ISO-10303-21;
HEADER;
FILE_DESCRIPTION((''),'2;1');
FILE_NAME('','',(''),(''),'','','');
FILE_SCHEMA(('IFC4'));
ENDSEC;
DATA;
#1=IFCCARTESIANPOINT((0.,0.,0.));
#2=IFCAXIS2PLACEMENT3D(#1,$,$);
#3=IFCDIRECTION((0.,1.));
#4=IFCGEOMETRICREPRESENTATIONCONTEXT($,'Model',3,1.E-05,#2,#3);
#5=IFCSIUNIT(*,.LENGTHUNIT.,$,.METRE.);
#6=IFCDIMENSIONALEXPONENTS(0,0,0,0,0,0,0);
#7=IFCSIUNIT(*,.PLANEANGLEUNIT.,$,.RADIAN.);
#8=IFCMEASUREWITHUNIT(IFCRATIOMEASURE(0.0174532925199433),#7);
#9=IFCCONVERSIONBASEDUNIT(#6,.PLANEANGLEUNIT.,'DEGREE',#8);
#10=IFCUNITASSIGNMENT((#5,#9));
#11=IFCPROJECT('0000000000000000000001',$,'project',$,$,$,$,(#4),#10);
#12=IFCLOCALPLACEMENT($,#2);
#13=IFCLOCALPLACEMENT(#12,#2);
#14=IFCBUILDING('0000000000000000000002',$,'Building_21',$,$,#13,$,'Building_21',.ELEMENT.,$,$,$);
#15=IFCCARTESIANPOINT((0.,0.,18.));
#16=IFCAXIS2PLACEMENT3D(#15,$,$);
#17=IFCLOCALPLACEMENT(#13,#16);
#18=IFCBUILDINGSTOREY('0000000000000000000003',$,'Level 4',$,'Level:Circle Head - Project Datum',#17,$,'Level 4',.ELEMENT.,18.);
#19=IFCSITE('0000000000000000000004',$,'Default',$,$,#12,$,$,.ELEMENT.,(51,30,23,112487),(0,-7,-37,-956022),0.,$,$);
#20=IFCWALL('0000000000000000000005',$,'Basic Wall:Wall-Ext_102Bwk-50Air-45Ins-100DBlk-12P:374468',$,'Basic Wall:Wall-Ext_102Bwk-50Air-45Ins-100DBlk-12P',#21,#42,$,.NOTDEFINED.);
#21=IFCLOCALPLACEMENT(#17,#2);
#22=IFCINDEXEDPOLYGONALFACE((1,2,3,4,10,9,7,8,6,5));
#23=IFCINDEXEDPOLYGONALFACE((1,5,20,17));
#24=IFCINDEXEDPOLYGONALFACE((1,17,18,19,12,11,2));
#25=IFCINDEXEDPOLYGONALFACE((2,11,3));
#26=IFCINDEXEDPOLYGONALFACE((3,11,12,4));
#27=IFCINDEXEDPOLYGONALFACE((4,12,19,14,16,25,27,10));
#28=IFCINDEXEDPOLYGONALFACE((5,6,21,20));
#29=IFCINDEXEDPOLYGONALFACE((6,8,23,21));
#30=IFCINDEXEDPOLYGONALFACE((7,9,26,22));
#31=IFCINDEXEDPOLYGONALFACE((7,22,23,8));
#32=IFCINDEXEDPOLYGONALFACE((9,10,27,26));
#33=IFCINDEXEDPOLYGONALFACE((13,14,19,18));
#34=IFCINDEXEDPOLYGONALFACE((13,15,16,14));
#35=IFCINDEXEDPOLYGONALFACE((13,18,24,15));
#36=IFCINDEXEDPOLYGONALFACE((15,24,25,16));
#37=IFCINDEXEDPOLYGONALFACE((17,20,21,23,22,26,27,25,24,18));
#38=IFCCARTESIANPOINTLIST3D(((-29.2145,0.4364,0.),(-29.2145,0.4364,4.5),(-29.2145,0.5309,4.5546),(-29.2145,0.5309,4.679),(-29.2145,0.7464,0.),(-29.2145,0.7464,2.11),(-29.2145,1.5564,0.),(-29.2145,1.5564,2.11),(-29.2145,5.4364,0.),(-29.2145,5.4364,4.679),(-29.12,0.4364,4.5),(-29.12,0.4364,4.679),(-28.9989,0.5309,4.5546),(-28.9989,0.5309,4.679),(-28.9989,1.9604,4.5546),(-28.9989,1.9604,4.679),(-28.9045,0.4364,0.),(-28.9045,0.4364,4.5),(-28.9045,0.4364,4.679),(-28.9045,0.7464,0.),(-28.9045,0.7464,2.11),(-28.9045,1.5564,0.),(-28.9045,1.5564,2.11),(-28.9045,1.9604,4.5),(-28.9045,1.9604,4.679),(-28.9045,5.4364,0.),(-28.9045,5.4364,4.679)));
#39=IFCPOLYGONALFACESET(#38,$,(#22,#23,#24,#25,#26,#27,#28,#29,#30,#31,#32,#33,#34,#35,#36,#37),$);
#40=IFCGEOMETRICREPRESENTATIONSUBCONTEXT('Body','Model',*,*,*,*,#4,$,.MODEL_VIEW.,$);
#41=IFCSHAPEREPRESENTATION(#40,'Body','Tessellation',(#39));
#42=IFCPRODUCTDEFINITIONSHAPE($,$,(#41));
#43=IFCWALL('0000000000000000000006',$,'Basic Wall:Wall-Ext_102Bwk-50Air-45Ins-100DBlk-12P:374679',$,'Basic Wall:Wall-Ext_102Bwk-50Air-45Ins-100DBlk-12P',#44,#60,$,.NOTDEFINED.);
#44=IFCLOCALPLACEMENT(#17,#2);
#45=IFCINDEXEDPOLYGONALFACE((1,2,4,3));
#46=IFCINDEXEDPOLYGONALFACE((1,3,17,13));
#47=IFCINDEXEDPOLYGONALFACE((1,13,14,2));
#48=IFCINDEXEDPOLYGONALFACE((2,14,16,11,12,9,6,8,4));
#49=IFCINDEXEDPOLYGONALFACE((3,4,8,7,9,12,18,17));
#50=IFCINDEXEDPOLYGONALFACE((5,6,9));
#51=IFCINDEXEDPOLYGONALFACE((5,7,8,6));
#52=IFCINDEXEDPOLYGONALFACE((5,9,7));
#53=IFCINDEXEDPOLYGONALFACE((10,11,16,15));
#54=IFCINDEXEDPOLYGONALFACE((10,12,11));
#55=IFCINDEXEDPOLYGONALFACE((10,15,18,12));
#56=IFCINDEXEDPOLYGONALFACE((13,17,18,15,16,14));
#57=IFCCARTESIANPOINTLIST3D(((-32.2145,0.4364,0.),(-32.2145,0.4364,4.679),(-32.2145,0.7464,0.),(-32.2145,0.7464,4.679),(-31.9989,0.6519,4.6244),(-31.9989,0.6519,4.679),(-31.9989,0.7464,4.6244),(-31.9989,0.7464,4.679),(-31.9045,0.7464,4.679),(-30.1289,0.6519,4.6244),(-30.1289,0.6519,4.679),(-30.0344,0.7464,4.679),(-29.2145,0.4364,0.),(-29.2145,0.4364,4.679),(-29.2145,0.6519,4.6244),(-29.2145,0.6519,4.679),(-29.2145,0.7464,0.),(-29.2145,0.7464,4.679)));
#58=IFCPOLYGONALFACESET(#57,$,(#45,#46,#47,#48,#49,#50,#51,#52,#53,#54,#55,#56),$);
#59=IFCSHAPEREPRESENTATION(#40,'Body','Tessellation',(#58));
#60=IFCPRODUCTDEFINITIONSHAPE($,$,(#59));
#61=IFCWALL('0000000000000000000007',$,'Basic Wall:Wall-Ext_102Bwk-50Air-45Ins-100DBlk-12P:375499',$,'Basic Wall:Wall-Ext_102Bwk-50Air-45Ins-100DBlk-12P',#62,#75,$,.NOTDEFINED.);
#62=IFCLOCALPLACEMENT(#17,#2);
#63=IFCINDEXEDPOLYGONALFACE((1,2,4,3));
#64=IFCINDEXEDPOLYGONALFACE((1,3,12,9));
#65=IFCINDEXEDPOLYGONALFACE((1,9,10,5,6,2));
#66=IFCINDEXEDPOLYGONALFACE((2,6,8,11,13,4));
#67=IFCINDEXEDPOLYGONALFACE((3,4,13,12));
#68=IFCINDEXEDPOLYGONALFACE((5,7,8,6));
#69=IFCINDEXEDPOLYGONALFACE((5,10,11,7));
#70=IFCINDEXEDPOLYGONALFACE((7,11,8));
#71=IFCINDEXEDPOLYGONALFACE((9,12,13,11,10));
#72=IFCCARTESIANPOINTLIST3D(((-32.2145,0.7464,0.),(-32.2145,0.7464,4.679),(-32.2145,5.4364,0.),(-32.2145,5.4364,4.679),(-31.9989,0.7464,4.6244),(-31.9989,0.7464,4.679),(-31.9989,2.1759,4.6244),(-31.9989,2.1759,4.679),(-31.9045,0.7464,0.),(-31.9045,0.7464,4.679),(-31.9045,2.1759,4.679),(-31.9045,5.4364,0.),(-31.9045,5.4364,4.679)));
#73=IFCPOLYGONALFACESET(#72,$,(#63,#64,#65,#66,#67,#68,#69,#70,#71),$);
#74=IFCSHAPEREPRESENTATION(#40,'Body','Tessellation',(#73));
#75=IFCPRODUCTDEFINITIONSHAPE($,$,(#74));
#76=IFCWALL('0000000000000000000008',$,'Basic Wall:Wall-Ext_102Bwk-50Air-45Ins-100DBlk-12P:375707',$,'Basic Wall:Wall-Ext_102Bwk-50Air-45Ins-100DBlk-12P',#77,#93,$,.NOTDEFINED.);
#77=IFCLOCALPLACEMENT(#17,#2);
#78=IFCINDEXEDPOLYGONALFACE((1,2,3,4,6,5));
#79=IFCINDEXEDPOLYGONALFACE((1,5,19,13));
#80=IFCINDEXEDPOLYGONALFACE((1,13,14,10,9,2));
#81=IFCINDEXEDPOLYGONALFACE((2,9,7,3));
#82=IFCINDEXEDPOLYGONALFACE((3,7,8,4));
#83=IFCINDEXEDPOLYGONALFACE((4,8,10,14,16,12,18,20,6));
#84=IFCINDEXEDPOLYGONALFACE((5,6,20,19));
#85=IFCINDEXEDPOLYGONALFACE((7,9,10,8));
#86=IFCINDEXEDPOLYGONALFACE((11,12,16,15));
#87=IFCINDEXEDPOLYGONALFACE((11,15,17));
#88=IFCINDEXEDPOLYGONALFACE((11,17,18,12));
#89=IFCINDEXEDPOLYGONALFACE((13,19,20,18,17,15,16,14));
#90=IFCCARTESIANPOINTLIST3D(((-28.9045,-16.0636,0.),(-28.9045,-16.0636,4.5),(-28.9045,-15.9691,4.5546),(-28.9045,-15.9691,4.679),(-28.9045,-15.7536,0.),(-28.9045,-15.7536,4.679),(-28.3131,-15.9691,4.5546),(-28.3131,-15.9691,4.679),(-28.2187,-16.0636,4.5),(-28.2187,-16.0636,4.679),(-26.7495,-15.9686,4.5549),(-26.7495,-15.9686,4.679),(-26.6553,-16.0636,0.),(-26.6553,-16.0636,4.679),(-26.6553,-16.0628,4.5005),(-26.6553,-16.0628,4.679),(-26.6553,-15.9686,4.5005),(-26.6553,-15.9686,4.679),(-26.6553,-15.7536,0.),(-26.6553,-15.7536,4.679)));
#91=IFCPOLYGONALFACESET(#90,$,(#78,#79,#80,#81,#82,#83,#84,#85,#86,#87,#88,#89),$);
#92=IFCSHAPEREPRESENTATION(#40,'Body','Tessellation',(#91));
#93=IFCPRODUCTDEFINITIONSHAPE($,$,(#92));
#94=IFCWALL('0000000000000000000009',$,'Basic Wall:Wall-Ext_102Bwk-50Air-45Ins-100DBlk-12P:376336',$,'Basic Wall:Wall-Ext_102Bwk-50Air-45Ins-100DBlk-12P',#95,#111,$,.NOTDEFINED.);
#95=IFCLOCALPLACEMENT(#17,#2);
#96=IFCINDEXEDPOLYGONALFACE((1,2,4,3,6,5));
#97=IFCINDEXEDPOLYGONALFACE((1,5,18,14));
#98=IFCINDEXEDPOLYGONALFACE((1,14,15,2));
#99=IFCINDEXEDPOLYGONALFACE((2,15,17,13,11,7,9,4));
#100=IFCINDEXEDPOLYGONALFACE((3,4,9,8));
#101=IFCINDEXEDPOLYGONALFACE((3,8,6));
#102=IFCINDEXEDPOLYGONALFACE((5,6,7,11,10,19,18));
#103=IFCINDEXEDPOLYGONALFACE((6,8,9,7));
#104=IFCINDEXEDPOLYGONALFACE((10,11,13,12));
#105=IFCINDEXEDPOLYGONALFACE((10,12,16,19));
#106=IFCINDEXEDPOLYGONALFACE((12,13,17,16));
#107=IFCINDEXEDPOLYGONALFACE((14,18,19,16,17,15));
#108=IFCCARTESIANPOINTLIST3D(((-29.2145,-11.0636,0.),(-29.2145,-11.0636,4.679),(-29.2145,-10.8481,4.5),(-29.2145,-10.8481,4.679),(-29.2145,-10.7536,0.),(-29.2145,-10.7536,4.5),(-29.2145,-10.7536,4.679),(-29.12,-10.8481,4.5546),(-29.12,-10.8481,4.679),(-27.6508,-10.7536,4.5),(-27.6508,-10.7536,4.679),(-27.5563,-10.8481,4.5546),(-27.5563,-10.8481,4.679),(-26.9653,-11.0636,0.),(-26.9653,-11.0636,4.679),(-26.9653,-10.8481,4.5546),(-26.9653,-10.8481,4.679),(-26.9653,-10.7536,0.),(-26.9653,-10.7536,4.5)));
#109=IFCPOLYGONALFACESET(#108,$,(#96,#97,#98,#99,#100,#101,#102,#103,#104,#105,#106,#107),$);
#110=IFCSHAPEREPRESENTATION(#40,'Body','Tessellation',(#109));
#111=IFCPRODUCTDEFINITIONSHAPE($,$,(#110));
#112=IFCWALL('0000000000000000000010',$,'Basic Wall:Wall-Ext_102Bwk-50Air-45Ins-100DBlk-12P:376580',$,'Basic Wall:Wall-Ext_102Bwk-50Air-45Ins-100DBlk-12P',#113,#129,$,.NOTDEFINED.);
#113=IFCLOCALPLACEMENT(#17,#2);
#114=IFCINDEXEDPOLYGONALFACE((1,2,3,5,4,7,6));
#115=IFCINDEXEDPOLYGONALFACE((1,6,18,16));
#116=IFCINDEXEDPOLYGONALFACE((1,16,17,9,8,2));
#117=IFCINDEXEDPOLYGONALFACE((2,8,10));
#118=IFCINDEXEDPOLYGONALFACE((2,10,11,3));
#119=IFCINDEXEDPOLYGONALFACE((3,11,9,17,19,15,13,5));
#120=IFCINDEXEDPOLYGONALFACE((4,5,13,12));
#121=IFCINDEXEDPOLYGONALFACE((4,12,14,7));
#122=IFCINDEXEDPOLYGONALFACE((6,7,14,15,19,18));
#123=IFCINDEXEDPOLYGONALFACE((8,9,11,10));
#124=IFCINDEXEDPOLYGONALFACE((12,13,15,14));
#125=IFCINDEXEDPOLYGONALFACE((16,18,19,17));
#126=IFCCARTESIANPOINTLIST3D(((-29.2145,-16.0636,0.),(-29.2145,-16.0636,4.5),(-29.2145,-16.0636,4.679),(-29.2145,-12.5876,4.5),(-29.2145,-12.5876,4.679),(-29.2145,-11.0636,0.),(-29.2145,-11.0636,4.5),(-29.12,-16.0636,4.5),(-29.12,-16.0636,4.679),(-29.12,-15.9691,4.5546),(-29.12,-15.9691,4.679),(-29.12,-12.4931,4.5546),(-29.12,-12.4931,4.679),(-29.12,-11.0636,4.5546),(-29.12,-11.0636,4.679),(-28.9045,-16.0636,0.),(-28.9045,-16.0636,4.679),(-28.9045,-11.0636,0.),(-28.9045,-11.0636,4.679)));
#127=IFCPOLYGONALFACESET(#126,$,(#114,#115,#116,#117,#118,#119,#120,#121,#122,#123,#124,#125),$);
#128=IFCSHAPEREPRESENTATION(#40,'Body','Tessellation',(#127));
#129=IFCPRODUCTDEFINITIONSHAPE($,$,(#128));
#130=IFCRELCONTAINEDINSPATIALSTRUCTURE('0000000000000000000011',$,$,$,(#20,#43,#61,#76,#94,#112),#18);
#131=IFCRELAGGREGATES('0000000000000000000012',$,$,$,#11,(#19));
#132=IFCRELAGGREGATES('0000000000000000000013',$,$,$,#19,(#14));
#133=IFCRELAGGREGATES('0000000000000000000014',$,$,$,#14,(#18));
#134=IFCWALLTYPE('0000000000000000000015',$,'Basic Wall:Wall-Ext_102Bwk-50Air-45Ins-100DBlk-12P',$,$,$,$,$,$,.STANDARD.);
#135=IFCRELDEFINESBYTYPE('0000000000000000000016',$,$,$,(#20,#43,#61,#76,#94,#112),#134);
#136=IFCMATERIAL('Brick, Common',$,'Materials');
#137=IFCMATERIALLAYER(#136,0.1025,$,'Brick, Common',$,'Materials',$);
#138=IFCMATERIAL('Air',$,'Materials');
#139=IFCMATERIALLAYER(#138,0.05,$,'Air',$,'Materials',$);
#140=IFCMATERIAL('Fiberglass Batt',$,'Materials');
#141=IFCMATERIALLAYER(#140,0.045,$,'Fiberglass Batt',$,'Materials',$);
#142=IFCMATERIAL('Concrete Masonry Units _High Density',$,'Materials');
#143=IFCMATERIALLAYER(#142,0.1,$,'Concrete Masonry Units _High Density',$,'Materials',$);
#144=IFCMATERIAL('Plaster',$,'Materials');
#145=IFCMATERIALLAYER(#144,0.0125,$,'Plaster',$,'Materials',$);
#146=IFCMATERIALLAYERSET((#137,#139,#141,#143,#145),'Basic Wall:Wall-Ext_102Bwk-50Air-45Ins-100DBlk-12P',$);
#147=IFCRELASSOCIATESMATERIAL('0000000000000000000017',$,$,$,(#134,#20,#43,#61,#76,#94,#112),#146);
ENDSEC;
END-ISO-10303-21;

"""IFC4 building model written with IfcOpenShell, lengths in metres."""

from ifc_helpers import new_model, entity, si_unit, converted_unit, direction, frame, frame_2d, origin, place, context, subcontext, project, spatial, polyline, rectangle, extrude, clip, bounded_halfspace, material, layer, layer_set, layer_usage, type_object, element, save


model = new_model("IFC4")

# Units and contexts
model_context = context("Model", 3, precision=1e-05, world=origin(), true_north=direction((0.0, 1.0)))
body_context = subcontext(model_context, "Body", "Model", "MODEL_VIEW")
ifc_project = project(units=[si_unit("LENGTHUNIT", "METRE"), converted_unit("PLANEANGLEUNIT", "DEGREE", entity("IfcRatioMeasure", 0.0174532925199433), si_unit("PLANEANGLEUNIT", "RADIAN"), dimensions=[0, 0, 0, 0, 0, 0, 0])], contexts=[model_context])

# Site, building, storey
site_placement = place(None, origin())
site = spatial("IfcSite", under=ifc_project, at=site_placement, Name="Default", CompositionType="ELEMENT", RefLatitude=(51, 30, 23, 112487), RefLongitude=(0, -7, -37, -956022), RefElevation=0.0)
building_placement = place(site_placement, origin())
building = spatial("IfcBuilding", under=site, at=building_placement, Name="Building_21", LongName="Building_21", CompositionType="ELEMENT")
storey_placement = place(building_placement, frame((0.0, 0.0, 18.0)))
storey = spatial("IfcBuildingStorey", under=building, at=storey_placement, Name="Level 4", ObjectType="Level:Circle Head - Project Datum", LongName="Level 4", CompositionType="ELEMENT", Elevation=18.0)

# Shared definitions
ifc_material_1 = material(Name="Air", Category="Materials")

# Shared definitions
ifc_material_2 = material(Name="Brick, Common", Category="Materials")
ifc_layer_1 = layer(ifc_material_2, 0.1025, Name="Brick, Common", Category="Materials")
ifc_layer_2 = layer(ifc_material_1, 0.05, Name="Air", Category="Materials")
ifc_material_3 = material(Name="Fiberglass Batt", Category="Materials")
ifc_layer_3 = layer(ifc_material_3, 0.045, Name="Fiberglass Batt", Category="Materials")
ifc_material_4 = material(Name="Concrete Masonry Units _High Density", Category="Materials")
ifc_layer_4 = layer(ifc_material_4, 0.1, Name="Concrete Masonry Units _High Density", Category="Materials")
ifc_material_5 = material(Name="Plaster", Category="Materials")
ifc_layer_5 = layer(ifc_material_5, 0.0125, Name="Plaster", Category="Materials")
ifc_layer_set_1 = layer_set([ifc_layer_1, ifc_layer_2, ifc_layer_3, ifc_layer_4, ifc_layer_5], Name="Basic Wall:Wall-Ext_102Bwk-50Air-45Ins-100DBlk-12P")
wall_type = type_object("IfcWallType", Name="Basic Wall:Wall-Ext_102Bwk-50Air-45Ins-100DBlk-12P", PredefinedType="STANDARD", material=ifc_layer_set_1)

# Wall, opening
ifc_layer_usage_1 = layer_usage(ifc_layer_set_1, "AXIS2", "NEGATIVE", 0.155)
wall_1_placement = place(storey_placement, frame((-29.0595, 5.4364, 0.0), z_axis=(0.0, 0.0, 1.0), x_axis=(0.0, -1.0, 0.0)))
wall_1 = element("IfcWall", 1, at=wall_1_placement, inside=storey, type_object=wall_type, material=ifc_layer_usage_1, Name="Basic Wall:Wall-Ext_102Bwk-50Air-45Ins-100DBlk-12P:374468", ObjectType="Basic Wall:Wall-Ext_102Bwk-50Air-45Ins-100DBlk-12P", PredefinedType="NOTDEFINED", context=body_context, shape_type="Clipping", body=[
    clip(clip(extrude(rectangle(XDim=0.31, YDim=5.0, at=frame_2d((2.5, 0.0), x_axis=(0.0, 1.0))), origin(), (0.0, 0.0, 1.0), 4.679), bounded_halfspace(frame((5.0, 0.155, 4.5), z_axis=(0.0, 0.5, 0.866025), x_axis=(-1.0, 0.0, 0.0)), False, frame((5.0, 0.155, 4.5)), polyline([(0.0, 0.0), (-1.524, 0.0), (-1.524, -0.0945), (-0.0945, -0.0945), (0.0, 0.0)]))), bounded_halfspace(frame((5.0, -0.155, 4.5), z_axis=(0.5, 0.0, 0.866025), x_axis=(0.0, 1.0, 0.0)), False, frame((5.0, -0.155, 4.5)), polyline([(0.0, 0.0), (0.0, 0.0945), (-0.0945, 0.0), (0.0, 0.0)]))),
])
opening_1_placement = place(wall_1_placement, frame((3.88, -0.155, 0.0)))
element("IfcOpeningElement", 2, at=opening_1_placement, cuts=wall_1, PredefinedType="OPENING", context=body_context, shape_type="SweptSolid", body=[
    extrude(rectangle(XDim=2.11, YDim=0.81, at=frame_2d((1.055, 0.405), x_axis=(1.0, 0.0))), frame((0.0, 0.0, 0.0), z_axis=(0.0, 1.0, 0.0), x_axis=(0.0, 0.0, 1.0)), (0.0, 0.0, 1.0), 0.31),
])

# Walls
ifc_layer_usage_2 = layer_usage(ifc_layer_set_1, "AXIS2", "NEGATIVE", 0.155)
wall_2_placement = place(storey_placement, frame((-29.2145, 0.5914, 0.0), z_axis=(0.0, 0.0, 1.0), x_axis=(-1.0, 0.0, 0.0)))
element("IfcWall", 3, at=wall_2_placement, inside=storey, type_object=wall_type, material=ifc_layer_usage_2, Name="Basic Wall:Wall-Ext_102Bwk-50Air-45Ins-100DBlk-12P:374679", ObjectType="Basic Wall:Wall-Ext_102Bwk-50Air-45Ins-100DBlk-12P", PredefinedType="NOTDEFINED", context=body_context, shape_type="Clipping", body=[
    clip(clip(extrude(rectangle(XDim=3.0, YDim=0.31, at=frame_2d((1.5, 0.0), x_axis=(-1.0, 0.0))), origin(), (0.0, 0.0, 1.0), 4.679), bounded_halfspace(frame((0.0, -0.155, 4.679), z_axis=(0.0, 0.5, 0.866025), x_axis=(-1.0, 0.0, 0.0)), False, frame((0.0, -0.155, 4.679)), polyline([(0.0, 0.0), (0.8199, 0.0), (0.9144, 0.0945), (0.0, 0.0945), (0.0, 0.0)]))), bounded_halfspace(frame((2.69, -0.155, 4.679), z_axis=(0.5, 0.0, 0.866025), x_axis=(0.0, 1.0, 0.0)), False, frame((2.69, -0.155, 4.679)), polyline([(0.0, 0.0), (0.0945, 0.0), (0.0945, 0.0945), (0.0, 0.0)]))),
])
ifc_layer_usage_3 = layer_usage(ifc_layer_set_1, "AXIS2", "NEGATIVE", 0.155)
wall_3_placement = place(storey_placement, frame((-32.0595, 0.7464, 0.0), z_axis=(0.0, 0.0, 1.0), x_axis=(0.0, 1.0, 0.0)))
element("IfcWall", 4, at=wall_3_placement, inside=storey, type_object=wall_type, material=ifc_layer_usage_3, Name="Basic Wall:Wall-Ext_102Bwk-50Air-45Ins-100DBlk-12P:375499", ObjectType="Basic Wall:Wall-Ext_102Bwk-50Air-45Ins-100DBlk-12P", PredefinedType="NOTDEFINED", context=body_context, shape_type="Clipping", body=[
    clip(extrude(rectangle(XDim=4.69, YDim=0.31, at=frame_2d((2.345, 0.0), x_axis=(-1.0, 0.0))), origin(), (0.0, 0.0, 1.0), 4.679), bounded_halfspace(frame((0.0, -0.155, 4.679), z_axis=(0.0, 0.5, 0.866025), x_axis=(-1.0, 0.0, 0.0)), False, frame((0.0, -0.155, 4.679)), polyline([(0.0, 0.0), (1.4295, 0.0), (1.4295, 0.0945), (0.0, 0.0945), (0.0, 0.0)]))),
])

# Wall, opening
ifc_layer_usage_4 = layer_usage(ifc_layer_set_1, "AXIS2", "NEGATIVE", 0.155)
wall_4_placement = place(storey_placement, frame((-28.9045, -15.9086, 0.0)))
wall_4 = element("IfcWall", 5, at=wall_4_placement, inside=storey, type_object=wall_type, material=ifc_layer_usage_4, Name="Basic Wall:Wall-Ext_102Bwk-50Air-45Ins-100DBlk-12P:375707", ObjectType="Basic Wall:Wall-Ext_102Bwk-50Air-45Ins-100DBlk-12P", PredefinedType="NOTDEFINED", context=body_context, shape_type="Clipping", body=[
    clip(clip(extrude(rectangle(XDim=2.2492, YDim=0.31, at=frame_2d((1.1246, 0.0), x_axis=(-1.0, 0.0))), origin(), (0.0, 0.0, 1.0), 4.679), bounded_halfspace(frame((2.2492, -0.1542, 4.5005), z_axis=(0.5, 0.0, 0.866025), x_axis=(0.0, 1.0, 0.0)), False, frame((2.2492, -0.1542, 4.5005)), polyline([(0.0, 0.0), (0.0, 0.0942), (-0.0942, 0.0942), (0.0, 0.0)]))), bounded_halfspace(frame((0.0, -0.155, 4.5), z_axis=(0.0, -0.5, 0.866025), x_axis=(1.0, 0.0, 0.0)), False, frame((0.0, -0.155, 4.5)), polyline([(0.0, 0.0), (0.6858, 0.0), (0.5913, 0.0945), (0.0, 0.0945), (0.0, 0.0)]))),
])
opening_2_placement = place(wall_4_placement, frame((1.9392, 0.155, 0.0)))
element("IfcOpeningElement", 6, at=opening_2_placement, cuts=wall_4, PredefinedType="OPENING", context=body_context, shape_type="SweptSolid", body=[
    extrude(rectangle(XDim=2.11, YDim=0.31, at=frame_2d((0.0, 0.0), x_axis=(0.0, 1.0))), frame((0.155, 0.0, 1.055), z_axis=(0.0, 1.0, 0.0), x_axis=(-1.0, 0.0, 0.0)), (0.0, 0.0, 1.0), 0.81),
])

# Walls
ifc_layer_usage_5 = layer_usage(ifc_layer_set_1, "AXIS2", "NEGATIVE", 0.155)
wall_5_placement = place(storey_placement, frame((-26.9653, -10.9086, 0.0), z_axis=(0.0, 0.0, 1.0), x_axis=(-1.0, 0.0, 0.0)))
element("IfcWall", 7, at=wall_5_placement, inside=storey, type_object=wall_type, material=ifc_layer_usage_5, Name="Basic Wall:Wall-Ext_102Bwk-50Air-45Ins-100DBlk-12P:376336", ObjectType="Basic Wall:Wall-Ext_102Bwk-50Air-45Ins-100DBlk-12P", PredefinedType="NOTDEFINED", context=body_context, shape_type="Clipping", body=[
    clip(clip(extrude(rectangle(XDim=2.2492, YDim=0.31, at=frame_2d((1.1246, 0.0), x_axis=(-1.0, 0.0))), origin(), (0.0, 0.0, 1.0), 4.679), bounded_halfspace(frame((0.0, -0.155, 4.5), z_axis=(0.0, -0.5, 0.866025), x_axis=(1.0, 0.0, 0.0)), False, frame((0.0, -0.155, 4.5)), polyline([(0.0, 0.0), (0.6856, 0.0), (0.5911, 0.0945), (0.0, 0.0945), (0.0, 0.0)]))), bounded_halfspace(frame((2.2492, -0.155, 4.5), z_axis=(0.5, 0.0, 0.866025), x_axis=(0.0, 1.0, 0.0)), False, frame((2.2492, -0.155, 4.5)), polyline([(0.0, 0.0), (0.0, 0.0945), (-0.0945, 0.0945), (0.0, 0.0)]))),
])
ifc_layer_usage_6 = layer_usage(ifc_layer_set_1, "AXIS2", "NEGATIVE", 0.155)
wall_6_placement = place(storey_placement, frame((-29.0595, -11.0636, 0.0), z_axis=(0.0, 0.0, 1.0), x_axis=(0.0, -1.0, 0.0)))
element("IfcWall", 8, at=wall_6_placement, inside=storey, type_object=wall_type, material=ifc_layer_usage_6, Name="Basic Wall:Wall-Ext_102Bwk-50Air-45Ins-100DBlk-12P:376580", ObjectType="Basic Wall:Wall-Ext_102Bwk-50Air-45Ins-100DBlk-12P", PredefinedType="NOTDEFINED", context=body_context, shape_type="Clipping", body=[
    clip(clip(extrude(rectangle(XDim=5.0, YDim=0.31, at=frame_2d((2.5, 0.0), x_axis=(-1.0, 0.0))), origin(), (0.0, 0.0, 1.0), 4.679), bounded_halfspace(frame((5.0, -0.155, 4.5), z_axis=(0.5, 0.0, 0.866025), x_axis=(0.0, 1.0, 0.0)), False, frame((5.0, -0.155, 4.5)), polyline([(0.0, 0.0), (0.0, 0.0945), (-0.0945, 0.0945), (0.0, 0.0)]))), bounded_halfspace(frame((0.0, -0.155, 4.5), z_axis=(0.0, -0.5, 0.866025), x_axis=(1.0, 0.0, 0.0)), False, frame((0.0, -0.155, 4.5)), polyline([(0.0, 0.0), (1.524, 0.0), (1.4295, 0.0945), (0.0, 0.0945), (0.0, 0.0)]))),
])

save(model, "model.ifc")
